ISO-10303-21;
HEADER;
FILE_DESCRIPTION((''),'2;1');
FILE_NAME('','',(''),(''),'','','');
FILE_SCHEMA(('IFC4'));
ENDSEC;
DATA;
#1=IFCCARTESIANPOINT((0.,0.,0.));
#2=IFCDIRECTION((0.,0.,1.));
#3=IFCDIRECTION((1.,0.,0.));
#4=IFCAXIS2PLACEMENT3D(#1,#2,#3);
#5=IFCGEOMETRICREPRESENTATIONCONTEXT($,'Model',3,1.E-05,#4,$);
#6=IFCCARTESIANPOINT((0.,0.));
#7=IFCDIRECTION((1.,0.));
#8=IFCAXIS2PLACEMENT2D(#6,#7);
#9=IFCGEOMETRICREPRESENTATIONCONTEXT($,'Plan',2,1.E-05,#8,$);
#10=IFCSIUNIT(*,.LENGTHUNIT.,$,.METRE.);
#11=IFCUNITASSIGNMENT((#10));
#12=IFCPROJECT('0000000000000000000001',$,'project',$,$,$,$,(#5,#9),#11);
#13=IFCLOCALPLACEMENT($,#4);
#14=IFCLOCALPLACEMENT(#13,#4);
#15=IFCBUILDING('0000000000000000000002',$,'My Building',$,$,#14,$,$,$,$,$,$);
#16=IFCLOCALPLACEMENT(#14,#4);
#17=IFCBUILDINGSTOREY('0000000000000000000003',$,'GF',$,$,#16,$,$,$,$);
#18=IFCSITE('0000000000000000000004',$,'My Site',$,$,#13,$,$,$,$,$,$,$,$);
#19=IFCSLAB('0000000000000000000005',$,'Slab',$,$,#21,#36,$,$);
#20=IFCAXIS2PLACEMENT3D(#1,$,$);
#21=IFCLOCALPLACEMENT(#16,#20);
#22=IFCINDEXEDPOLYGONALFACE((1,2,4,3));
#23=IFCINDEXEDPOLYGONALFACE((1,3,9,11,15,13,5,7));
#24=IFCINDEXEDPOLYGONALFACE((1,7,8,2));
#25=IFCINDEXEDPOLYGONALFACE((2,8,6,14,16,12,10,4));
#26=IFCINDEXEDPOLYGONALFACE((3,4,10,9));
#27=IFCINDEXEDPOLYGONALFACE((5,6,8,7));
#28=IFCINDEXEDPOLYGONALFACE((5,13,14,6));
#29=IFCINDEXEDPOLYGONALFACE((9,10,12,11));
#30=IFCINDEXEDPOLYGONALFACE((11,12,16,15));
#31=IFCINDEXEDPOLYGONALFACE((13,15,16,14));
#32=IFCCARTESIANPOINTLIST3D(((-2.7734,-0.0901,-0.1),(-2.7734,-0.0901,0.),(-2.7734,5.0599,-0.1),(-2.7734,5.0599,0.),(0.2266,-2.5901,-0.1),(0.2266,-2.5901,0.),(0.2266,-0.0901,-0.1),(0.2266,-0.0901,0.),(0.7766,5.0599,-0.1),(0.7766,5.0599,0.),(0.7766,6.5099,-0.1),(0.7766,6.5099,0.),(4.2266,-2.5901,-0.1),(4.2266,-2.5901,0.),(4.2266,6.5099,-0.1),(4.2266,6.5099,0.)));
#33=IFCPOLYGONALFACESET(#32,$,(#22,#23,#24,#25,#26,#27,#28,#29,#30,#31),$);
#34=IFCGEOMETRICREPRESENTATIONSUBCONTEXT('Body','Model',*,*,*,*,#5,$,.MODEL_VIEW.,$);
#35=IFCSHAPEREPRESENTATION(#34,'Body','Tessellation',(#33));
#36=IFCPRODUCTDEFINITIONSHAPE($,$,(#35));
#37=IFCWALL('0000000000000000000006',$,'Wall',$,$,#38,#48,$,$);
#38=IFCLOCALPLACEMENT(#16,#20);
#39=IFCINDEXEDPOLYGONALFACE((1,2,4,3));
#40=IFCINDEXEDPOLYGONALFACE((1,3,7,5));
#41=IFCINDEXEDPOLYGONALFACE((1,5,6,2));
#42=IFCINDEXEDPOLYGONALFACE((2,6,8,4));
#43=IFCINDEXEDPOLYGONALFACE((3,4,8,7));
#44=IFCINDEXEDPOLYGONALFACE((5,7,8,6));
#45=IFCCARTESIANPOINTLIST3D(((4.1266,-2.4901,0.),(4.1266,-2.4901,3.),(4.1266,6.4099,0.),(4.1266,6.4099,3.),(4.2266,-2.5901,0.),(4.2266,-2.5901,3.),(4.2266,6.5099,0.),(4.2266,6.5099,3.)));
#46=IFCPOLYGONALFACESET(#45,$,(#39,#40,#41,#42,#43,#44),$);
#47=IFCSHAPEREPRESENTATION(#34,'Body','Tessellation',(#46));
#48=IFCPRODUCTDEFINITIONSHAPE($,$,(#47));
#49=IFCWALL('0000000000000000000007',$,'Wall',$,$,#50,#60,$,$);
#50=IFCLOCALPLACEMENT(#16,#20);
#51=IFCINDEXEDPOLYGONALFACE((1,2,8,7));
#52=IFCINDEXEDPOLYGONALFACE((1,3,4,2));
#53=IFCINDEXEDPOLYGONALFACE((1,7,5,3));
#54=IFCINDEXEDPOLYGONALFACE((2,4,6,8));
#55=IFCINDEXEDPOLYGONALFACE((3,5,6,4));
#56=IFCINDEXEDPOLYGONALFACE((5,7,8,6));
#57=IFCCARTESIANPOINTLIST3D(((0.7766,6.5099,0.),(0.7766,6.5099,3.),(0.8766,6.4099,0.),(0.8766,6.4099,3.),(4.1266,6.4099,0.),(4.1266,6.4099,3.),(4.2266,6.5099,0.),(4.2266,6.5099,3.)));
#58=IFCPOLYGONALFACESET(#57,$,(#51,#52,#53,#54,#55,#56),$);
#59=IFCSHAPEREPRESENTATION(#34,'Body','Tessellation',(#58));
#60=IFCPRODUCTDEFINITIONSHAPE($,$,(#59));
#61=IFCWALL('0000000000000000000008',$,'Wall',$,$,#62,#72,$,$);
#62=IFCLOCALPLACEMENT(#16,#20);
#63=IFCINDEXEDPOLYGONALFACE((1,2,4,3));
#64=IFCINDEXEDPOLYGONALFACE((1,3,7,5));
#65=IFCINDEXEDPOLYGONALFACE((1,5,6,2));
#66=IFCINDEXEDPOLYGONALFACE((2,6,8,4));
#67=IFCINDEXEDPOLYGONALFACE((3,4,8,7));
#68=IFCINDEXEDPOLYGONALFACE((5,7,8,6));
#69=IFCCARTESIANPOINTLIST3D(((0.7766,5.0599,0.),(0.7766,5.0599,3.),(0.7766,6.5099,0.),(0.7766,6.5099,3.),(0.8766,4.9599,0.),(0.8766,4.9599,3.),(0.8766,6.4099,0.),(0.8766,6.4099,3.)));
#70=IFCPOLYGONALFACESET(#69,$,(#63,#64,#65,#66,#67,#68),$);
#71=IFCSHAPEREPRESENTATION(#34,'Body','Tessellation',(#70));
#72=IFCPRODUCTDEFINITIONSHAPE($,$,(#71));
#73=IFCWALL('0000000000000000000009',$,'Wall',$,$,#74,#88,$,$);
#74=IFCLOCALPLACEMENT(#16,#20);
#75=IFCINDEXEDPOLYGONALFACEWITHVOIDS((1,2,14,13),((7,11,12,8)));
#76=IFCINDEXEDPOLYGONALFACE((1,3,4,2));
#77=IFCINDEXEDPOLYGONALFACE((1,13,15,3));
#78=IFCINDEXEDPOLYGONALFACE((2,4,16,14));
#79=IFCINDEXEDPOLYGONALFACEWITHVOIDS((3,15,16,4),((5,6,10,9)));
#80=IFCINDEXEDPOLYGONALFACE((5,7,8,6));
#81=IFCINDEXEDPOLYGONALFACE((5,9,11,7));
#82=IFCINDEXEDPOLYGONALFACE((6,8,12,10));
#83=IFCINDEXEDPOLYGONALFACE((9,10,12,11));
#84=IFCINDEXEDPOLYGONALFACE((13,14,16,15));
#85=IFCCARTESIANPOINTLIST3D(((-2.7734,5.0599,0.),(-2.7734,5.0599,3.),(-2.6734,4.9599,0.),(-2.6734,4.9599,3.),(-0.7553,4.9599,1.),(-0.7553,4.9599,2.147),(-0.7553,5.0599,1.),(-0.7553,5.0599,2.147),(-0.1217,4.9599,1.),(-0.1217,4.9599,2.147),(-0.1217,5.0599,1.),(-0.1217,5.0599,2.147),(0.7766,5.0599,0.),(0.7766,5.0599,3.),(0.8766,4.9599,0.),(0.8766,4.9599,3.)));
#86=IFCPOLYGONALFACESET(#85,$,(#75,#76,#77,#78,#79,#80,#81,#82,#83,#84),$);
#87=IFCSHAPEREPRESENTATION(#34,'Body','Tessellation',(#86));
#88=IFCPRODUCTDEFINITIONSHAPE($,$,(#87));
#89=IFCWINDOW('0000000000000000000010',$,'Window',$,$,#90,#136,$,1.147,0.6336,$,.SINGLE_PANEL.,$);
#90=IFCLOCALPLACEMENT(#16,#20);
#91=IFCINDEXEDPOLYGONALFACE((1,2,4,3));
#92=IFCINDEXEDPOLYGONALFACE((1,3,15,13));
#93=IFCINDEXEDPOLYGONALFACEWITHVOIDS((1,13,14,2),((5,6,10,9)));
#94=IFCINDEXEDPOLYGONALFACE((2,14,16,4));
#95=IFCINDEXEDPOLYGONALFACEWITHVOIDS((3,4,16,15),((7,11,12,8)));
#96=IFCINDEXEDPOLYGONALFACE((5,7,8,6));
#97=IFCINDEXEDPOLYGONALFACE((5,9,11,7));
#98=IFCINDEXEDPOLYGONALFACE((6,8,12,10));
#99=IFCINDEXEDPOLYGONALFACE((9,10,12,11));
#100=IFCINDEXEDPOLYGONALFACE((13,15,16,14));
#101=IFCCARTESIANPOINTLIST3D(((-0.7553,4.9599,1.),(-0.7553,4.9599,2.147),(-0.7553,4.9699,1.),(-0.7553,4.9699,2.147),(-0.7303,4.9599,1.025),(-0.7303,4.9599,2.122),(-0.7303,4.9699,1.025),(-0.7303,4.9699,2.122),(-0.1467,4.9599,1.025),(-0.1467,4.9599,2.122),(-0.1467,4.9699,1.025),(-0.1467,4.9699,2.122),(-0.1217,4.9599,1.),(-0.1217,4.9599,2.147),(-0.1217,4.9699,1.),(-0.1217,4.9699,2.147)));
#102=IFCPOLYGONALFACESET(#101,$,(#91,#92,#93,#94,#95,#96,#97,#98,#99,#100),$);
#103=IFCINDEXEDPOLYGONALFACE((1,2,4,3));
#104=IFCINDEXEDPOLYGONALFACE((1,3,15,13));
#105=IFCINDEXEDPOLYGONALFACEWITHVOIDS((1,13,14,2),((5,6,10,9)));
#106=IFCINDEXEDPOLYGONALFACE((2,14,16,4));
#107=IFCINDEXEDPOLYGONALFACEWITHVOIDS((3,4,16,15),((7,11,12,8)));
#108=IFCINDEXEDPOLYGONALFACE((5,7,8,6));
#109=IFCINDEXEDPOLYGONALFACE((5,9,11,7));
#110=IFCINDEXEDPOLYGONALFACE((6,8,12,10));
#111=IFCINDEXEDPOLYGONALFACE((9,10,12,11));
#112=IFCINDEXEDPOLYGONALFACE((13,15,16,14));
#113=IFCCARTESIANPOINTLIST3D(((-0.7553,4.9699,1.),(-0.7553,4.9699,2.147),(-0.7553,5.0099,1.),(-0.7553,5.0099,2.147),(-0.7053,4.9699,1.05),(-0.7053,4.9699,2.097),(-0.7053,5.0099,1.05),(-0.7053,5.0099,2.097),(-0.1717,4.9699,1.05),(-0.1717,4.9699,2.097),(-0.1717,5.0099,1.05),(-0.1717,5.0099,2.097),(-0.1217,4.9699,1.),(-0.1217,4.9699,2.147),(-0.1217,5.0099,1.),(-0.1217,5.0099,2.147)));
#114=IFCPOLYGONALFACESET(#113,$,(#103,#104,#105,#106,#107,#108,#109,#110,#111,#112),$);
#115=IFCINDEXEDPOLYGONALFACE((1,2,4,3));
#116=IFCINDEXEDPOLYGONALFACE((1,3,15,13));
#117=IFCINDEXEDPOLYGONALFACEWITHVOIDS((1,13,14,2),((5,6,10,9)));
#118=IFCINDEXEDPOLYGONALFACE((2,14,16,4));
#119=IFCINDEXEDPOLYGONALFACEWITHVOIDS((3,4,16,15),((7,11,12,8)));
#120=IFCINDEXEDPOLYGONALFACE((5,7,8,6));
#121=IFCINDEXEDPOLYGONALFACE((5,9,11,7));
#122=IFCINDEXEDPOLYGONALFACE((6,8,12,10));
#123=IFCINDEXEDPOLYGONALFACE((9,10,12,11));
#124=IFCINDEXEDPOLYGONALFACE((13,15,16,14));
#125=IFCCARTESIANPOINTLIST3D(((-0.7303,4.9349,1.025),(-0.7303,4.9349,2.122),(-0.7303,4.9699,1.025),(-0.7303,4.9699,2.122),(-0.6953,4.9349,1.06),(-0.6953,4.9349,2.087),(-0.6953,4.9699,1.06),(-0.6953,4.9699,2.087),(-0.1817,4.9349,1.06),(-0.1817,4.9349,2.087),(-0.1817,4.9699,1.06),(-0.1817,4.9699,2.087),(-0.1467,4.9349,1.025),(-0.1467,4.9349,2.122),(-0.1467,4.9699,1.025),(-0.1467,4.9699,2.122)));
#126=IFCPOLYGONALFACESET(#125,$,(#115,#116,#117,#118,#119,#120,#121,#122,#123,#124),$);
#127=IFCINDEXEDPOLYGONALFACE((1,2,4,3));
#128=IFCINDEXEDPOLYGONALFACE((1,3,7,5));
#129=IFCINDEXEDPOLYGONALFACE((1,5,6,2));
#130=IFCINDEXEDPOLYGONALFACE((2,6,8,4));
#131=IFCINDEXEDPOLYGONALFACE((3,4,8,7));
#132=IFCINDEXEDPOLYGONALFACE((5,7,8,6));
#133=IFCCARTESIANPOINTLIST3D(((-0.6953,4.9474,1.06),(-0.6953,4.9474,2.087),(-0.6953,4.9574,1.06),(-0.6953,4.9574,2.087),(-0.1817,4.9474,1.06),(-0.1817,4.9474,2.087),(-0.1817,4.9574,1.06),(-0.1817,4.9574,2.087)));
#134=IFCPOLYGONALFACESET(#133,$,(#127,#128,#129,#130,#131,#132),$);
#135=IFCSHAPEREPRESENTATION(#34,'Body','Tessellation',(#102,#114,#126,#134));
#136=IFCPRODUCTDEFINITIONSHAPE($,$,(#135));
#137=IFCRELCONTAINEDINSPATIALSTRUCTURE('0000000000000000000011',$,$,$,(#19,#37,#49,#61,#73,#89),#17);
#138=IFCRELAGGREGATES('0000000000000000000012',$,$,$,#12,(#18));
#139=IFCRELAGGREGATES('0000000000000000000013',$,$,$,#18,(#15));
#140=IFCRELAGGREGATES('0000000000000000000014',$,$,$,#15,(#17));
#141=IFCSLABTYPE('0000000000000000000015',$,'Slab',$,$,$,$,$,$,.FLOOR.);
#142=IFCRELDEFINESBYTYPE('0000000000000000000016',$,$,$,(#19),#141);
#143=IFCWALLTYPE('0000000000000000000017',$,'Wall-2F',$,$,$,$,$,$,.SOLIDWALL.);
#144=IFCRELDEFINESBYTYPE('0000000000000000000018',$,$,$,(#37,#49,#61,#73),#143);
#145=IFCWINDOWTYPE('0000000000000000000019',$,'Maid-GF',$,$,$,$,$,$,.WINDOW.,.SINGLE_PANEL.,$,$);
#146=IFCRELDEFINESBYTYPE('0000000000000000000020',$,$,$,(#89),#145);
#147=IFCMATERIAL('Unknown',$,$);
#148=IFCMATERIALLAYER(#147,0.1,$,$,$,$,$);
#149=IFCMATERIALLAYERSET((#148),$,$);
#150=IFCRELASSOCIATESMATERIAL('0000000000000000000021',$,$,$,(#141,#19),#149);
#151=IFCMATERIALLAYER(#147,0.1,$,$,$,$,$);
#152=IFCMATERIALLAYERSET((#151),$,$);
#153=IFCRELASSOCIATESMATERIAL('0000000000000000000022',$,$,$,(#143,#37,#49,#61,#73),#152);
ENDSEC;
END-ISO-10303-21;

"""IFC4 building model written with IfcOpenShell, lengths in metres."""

from ifc_helpers import new_model, entity, si_unit, frame, origin_with_axes, origin_2d_with_axis, place, context, subcontext, project, spatial, line, indexed_curve, outline, extrude, shape, source, transform, mapped, material, layer, layer_set, layer_usage, type_object, type_shapes, element, fill, save


model = new_model("IFC4")

# Units and contexts
model_context = context("Model", 3, precision=1e-05, world=origin_with_axes())
plan_context = context("Plan", 2, precision=1e-05, world=origin_2d_with_axis())
body_context_1 = subcontext(model_context, "Body", "Model", "MODEL_VIEW")
body_context_2 = subcontext(plan_context, "Body", "Plan", "PLAN_VIEW")
ifc_project = project(units=[si_unit("LENGTHUNIT", "METRE")], contexts=[model_context, plan_context])

# Site, building, storey
site_placement = place(None, origin_with_axes())
site = spatial("IfcSite", under=ifc_project, at=site_placement, Name="My Site")
building_placement = place(site_placement, origin_with_axes())
building = spatial("IfcBuilding", under=site, at=building_placement, Name="My Building")
storey_placement = place(building_placement, origin_with_axes())
storey = spatial("IfcBuildingStorey", under=building, at=storey_placement, Name="GF")

# Slab
ifc_material = material(Name="Unknown")
ifc_layer_1 = layer(ifc_material, 0.1)
ifc_layer_set_1 = layer_set([ifc_layer_1])
ifc_layer_usage_1 = layer_usage(ifc_layer_set_1, "AXIS3", "POSITIVE", -0.1)
slab_type = type_object("IfcSlabType", Name="Slab", PredefinedType="FLOOR", material=ifc_layer_set_1)
slab_placement = place(storey_placement, frame((4.2266, -2.5901, 0.0), z_axis=(0.0, 0.0, 1.0), x_axis=(1.0, 0.0, 0.0)))
element("IfcSlab", 1, at=slab_placement, inside=storey, type_object=slab_type, material=ifc_layer_usage_1, Name="Slab", context=body_context_1, shape_type="SweptSolid", body=[
    extrude(outline(indexed_curve([(0.0, 0.0), (0.0, 9.1), (-3.45, 9.1), (-3.45, 7.65), (-7.0, 7.65), (-7.0, 2.5), (-4.0, 2.5), (-4.0, 0.0), (0.0, 0.0)])), frame((0.0, 0.0, -0.1), z_axis=(0.0, 0.0, 1.0), x_axis=(1.0, 0.0, 0.0)), (0.0, 0.0, 1.0), 0.1),
])

# Shared definitions
ifc_layer_2 = layer(ifc_material, 0.1)
ifc_layer_set_2 = layer_set([ifc_layer_2])
wall_type = type_object("IfcWallType", Name="Wall-2F", PredefinedType="SOLIDWALL", material=ifc_layer_set_2)

# Walls
ifc_layer_usage_2 = layer_usage(ifc_layer_set_2, "AXIS2", "POSITIVE", 0.0)
wall_1_placement = place(storey_placement, frame((4.2266, -2.5901, 0.0), z_axis=(0.0, 0.0, 1.0), x_axis=(0.0, 1.0, 0.0)))
element("IfcWall", 2, at=wall_1_placement, inside=storey, type_object=wall_type, material=ifc_layer_usage_2, Name="Wall", context=body_context_1, shape_type="SweptSolid", body=[
    extrude(outline(indexed_curve([(0.0, 0.0), (0.1, 0.1), (9.0, 0.1), (9.1, 0.0)], segments=[line(1, 2, 3, 4, 1)])), origin_with_axes(), (0.0, 0.0, 1.0), 3.0),
])
ifc_layer_usage_3 = layer_usage(ifc_layer_set_2, "AXIS2", "POSITIVE", 0.0)
wall_2_placement = place(storey_placement, frame((4.2266, 6.5099, 0.0), z_axis=(0.0, 0.0, 1.0), x_axis=(-1.0, 0.0, 0.0)))
element("IfcWall", 3, at=wall_2_placement, inside=storey, type_object=wall_type, material=ifc_layer_usage_3, Name="Wall", context=body_context_1, shape_type="SweptSolid", body=[
    extrude(outline(indexed_curve([(0.0, 0.0), (0.1, 0.1), (3.35, 0.1), (3.45, 0.0)], segments=[line(1, 2, 3, 4, 1)])), origin_with_axes(), (0.0, 0.0, 1.0), 3.0),
])
ifc_layer_usage_4 = layer_usage(ifc_layer_set_2, "AXIS2", "POSITIVE", 0.0)
wall_3_placement = place(storey_placement, frame((0.7766, 6.5099, 0.0), z_axis=(0.0, 0.0, 1.0), x_axis=(0.0, -1.0, 0.0)))
element("IfcWall", 4, at=wall_3_placement, inside=storey, type_object=wall_type, material=ifc_layer_usage_4, Name="Wall", context=body_context_1, shape_type="SweptSolid", body=[
    extrude(outline(indexed_curve([(0.0, 0.0), (0.1, 0.1), (1.55, 0.1), (1.45, 0.0)], segments=[line(1, 2, 3, 4, 1)])), origin_with_axes(), (0.0, 0.0, 1.0), 3.0),
])

# Wall, opening, window
ifc_layer_usage_5 = layer_usage(ifc_layer_set_2, "AXIS2", "POSITIVE", 0.0)
wall_4_placement = place(storey_placement, frame((0.7766, 5.0599, 0.0), z_axis=(0.0, 0.0, 1.0), x_axis=(-1.0, 0.0, 0.0)))
wall_4 = element("IfcWall", 5, at=wall_4_placement, inside=storey, type_object=wall_type, material=ifc_layer_usage_5, Name="Wall", context=body_context_1, shape_type="SweptSolid", body=[
    extrude(outline(indexed_curve([(0.0, 0.0), (-0.1, 0.1), (3.45, 0.1), (3.55, 0.0)], segments=[line(1, 2, 3, 4, 1)])), origin_with_axes(), (0.0, 0.0, 1.0), 3.0),
])
shared_shape_1 = source(origin_with_axes(), body_context_1, "Body", "SweptSolid", [
    extrude(outline(indexed_curve([(0.0, 0.0), (0.6336, 0.0), (0.6336, 1.147), (0.0, 1.147)], segments=[line(1, 2, 3, 4, 1)])), frame((0.0, -0.6, 0.0), z_axis=(0.0, -1.0, 0.0), x_axis=(1.0, 0.0, 0.0)), (0.0, 0.0, -1.0), 1.2),
])
opening_1_placement = place(wall_4_placement, frame((0.8983, 0.0, 1.0), z_axis=(0.0, 0.0, 1.0), x_axis=(1.0, 0.0, 0.0)))
opening_1 = element("IfcOpeningElement", 6, at=opening_1_placement, cuts=wall_4, PredefinedType="OPENING", context=body_context_1, shape_type="MappedRepresentation", body=[
    mapped(shared_shape_1, transform((0.0, 0.0, 0.0), x_axis=(1.0, 0.0, 0.0), y_axis=(0.0, 1.0, 0.0), z_axis=(0.0, 0.0, 1.0), scale=1.0)),
])
window_type_1 = type_object("IfcWindowType", Name="Maid-GF", PartitioningType="SINGLE_PANEL", PredefinedType="WINDOW")
shared_shape_2 = source(origin_with_axes(), body_context_1, "Body", "SweptSolid", [
    extrude(outline(indexed_curve([(0.0, 0.0), (0.6336, 0.0), (0.6336, 1.147), (0.0, 1.147)], segments=[line(1, 2, 3, 4, 1)]), holes=[indexed_curve([(0.025, 0.025), (0.6086, 0.025), (0.6086, 1.122), (0.025, 1.122)], segments=[line(1, 2, 3, 4, 1)])]), frame((0.0, 0.09, 0.0), z_axis=(0.0, -1.0, 0.0), x_axis=(1.0, 0.0, 0.0)), (0.0, 0.0, -1.0), 0.01),
    extrude(outline(indexed_curve([(0.0, 0.0), (0.6336, 0.0), (0.6336, 1.147), (0.0, 1.147)], segments=[line(1, 2, 3, 4, 1)]), holes=[indexed_curve([(0.05, 0.05), (0.5836, 0.05), (0.5836, 1.097), (0.05, 1.097)], segments=[line(1, 2, 3, 4, 1)])]), frame((0.0, 0.05, 0.0), z_axis=(0.0, -1.0, 0.0), x_axis=(1.0, 0.0, 0.0)), (0.0, 0.0, -1.0), 0.04),
    extrude(outline(indexed_curve([(0.0, 0.0), (0.5836, 0.0), (0.5836, 1.097), (0.0, 1.097)], segments=[line(1, 2, 3, 4, 1)]), holes=[indexed_curve([(0.035, 0.035), (0.5486, 0.035), (0.5486, 1.062), (0.035, 1.062)], segments=[line(1, 2, 3, 4, 1)])]), frame((0.025, 0.09, 0.025), z_axis=(0.0, -1.0, 0.0), x_axis=(1.0, 0.0, 0.0)), (0.0, 0.0, -1.0), 0.035),
    extrude(outline(indexed_curve([(0.035, 0.035), (0.5486, 0.035), (0.5486, 1.062), (0.035, 1.062)], segments=[line(1, 2, 3, 4, 1)])), frame((0.025, 0.1025, 0.025), z_axis=(0.0, -1.0, 0.0), x_axis=(1.0, 0.0, 0.0)), (0.0, 0.0, -1.0), 0.01),
])
shared_shape_3 = source(origin_with_axes(), body_context_2, "Body", "Curve2D", [
    entity("IfcIndexedPolyCurve", entity("IfcCartesianPointList2D", [[0.05, 0.05], [0.5836, 0.05]])),
    entity("IfcIndexedPolyCurve", entity("IfcCartesianPointList2D", [[0.0, 0.1], [0.025, 0.1], [0.025, 0.09], [0.05, 0.09], [0.05, 0.05], [0.0, 0.05]]), [entity("IfcLineIndex", [1, 2, 3, 4, 5, 6, 1])]),
    entity("IfcIndexedPolyCurve", entity("IfcCartesianPointList2D", [[0.6336, 0.1], [0.6086, 0.1], [0.6086, 0.09], [0.5836, 0.09], [0.5836, 0.05], [0.6336, 0.05]]), [entity("IfcLineIndex", [1, 2, 3, 4, 5, 6, 1])]),
    entity("IfcIndexedPolyCurve", entity("IfcCartesianPointList2D", [[0.025, 0.09], [0.06, 0.09], [0.06, 0.125], [0.025, 0.125]]), [entity("IfcLineIndex", [1, 2, 3, 4, 1])]),
    entity("IfcIndexedPolyCurve", entity("IfcCartesianPointList2D", [[0.6086, 0.09], [0.5736, 0.09], [0.5736, 0.125], [0.6086, 0.125]]), [entity("IfcLineIndex", [1, 2, 3, 4, 1])]),
    entity("IfcIndexedPolyCurve", entity("IfcCartesianPointList2D", [[0.06, 0.09], [0.5736, 0.09]])),
    entity("IfcIndexedPolyCurve", entity("IfcCartesianPointList2D", [[0.06, 0.125], [0.5736, 0.125]])),
    entity("IfcIndexedPolyCurve", entity("IfcCartesianPointList2D", [[0.06, 0.1075], [0.5736, 0.1075]])),
])
type_shapes(window_type_1, [shared_shape_2, shared_shape_3])
window_1_placement = place(opening_1_placement, frame((0.0, 0.0, 0.0), z_axis=(0.0, 0.0, 1.0), x_axis=(1.0, 0.0, 0.0)))
window_1 = element("IfcWindow", 7, at=window_1_placement, inside=storey, type_object=window_type_1, Name="Window", OverallHeight=1.147, OverallWidth=0.6336, PartitioningType="SINGLE_PANEL", shapes=[
    shape(body_context_1, "Body", "MappedRepresentation", [mapped(shared_shape_2, transform((0.0, 0.0, 0.0), x_axis=(1.0, 0.0, 0.0), y_axis=(0.0, 1.0, 0.0), z_axis=(0.0, 0.0, 1.0), scale=1.0))]),
    shape(body_context_2, "Body", "MappedRepresentation", [mapped(shared_shape_3, transform((0.0, 0.0, 0.0), x_axis=(1.0, 0.0, 0.0), y_axis=(0.0, 1.0, 0.0), z_axis=(0.0, 0.0, 1.0), scale=1.0))]),
])
fill(opening_1, window_1)

save(model, "model.ifc")
